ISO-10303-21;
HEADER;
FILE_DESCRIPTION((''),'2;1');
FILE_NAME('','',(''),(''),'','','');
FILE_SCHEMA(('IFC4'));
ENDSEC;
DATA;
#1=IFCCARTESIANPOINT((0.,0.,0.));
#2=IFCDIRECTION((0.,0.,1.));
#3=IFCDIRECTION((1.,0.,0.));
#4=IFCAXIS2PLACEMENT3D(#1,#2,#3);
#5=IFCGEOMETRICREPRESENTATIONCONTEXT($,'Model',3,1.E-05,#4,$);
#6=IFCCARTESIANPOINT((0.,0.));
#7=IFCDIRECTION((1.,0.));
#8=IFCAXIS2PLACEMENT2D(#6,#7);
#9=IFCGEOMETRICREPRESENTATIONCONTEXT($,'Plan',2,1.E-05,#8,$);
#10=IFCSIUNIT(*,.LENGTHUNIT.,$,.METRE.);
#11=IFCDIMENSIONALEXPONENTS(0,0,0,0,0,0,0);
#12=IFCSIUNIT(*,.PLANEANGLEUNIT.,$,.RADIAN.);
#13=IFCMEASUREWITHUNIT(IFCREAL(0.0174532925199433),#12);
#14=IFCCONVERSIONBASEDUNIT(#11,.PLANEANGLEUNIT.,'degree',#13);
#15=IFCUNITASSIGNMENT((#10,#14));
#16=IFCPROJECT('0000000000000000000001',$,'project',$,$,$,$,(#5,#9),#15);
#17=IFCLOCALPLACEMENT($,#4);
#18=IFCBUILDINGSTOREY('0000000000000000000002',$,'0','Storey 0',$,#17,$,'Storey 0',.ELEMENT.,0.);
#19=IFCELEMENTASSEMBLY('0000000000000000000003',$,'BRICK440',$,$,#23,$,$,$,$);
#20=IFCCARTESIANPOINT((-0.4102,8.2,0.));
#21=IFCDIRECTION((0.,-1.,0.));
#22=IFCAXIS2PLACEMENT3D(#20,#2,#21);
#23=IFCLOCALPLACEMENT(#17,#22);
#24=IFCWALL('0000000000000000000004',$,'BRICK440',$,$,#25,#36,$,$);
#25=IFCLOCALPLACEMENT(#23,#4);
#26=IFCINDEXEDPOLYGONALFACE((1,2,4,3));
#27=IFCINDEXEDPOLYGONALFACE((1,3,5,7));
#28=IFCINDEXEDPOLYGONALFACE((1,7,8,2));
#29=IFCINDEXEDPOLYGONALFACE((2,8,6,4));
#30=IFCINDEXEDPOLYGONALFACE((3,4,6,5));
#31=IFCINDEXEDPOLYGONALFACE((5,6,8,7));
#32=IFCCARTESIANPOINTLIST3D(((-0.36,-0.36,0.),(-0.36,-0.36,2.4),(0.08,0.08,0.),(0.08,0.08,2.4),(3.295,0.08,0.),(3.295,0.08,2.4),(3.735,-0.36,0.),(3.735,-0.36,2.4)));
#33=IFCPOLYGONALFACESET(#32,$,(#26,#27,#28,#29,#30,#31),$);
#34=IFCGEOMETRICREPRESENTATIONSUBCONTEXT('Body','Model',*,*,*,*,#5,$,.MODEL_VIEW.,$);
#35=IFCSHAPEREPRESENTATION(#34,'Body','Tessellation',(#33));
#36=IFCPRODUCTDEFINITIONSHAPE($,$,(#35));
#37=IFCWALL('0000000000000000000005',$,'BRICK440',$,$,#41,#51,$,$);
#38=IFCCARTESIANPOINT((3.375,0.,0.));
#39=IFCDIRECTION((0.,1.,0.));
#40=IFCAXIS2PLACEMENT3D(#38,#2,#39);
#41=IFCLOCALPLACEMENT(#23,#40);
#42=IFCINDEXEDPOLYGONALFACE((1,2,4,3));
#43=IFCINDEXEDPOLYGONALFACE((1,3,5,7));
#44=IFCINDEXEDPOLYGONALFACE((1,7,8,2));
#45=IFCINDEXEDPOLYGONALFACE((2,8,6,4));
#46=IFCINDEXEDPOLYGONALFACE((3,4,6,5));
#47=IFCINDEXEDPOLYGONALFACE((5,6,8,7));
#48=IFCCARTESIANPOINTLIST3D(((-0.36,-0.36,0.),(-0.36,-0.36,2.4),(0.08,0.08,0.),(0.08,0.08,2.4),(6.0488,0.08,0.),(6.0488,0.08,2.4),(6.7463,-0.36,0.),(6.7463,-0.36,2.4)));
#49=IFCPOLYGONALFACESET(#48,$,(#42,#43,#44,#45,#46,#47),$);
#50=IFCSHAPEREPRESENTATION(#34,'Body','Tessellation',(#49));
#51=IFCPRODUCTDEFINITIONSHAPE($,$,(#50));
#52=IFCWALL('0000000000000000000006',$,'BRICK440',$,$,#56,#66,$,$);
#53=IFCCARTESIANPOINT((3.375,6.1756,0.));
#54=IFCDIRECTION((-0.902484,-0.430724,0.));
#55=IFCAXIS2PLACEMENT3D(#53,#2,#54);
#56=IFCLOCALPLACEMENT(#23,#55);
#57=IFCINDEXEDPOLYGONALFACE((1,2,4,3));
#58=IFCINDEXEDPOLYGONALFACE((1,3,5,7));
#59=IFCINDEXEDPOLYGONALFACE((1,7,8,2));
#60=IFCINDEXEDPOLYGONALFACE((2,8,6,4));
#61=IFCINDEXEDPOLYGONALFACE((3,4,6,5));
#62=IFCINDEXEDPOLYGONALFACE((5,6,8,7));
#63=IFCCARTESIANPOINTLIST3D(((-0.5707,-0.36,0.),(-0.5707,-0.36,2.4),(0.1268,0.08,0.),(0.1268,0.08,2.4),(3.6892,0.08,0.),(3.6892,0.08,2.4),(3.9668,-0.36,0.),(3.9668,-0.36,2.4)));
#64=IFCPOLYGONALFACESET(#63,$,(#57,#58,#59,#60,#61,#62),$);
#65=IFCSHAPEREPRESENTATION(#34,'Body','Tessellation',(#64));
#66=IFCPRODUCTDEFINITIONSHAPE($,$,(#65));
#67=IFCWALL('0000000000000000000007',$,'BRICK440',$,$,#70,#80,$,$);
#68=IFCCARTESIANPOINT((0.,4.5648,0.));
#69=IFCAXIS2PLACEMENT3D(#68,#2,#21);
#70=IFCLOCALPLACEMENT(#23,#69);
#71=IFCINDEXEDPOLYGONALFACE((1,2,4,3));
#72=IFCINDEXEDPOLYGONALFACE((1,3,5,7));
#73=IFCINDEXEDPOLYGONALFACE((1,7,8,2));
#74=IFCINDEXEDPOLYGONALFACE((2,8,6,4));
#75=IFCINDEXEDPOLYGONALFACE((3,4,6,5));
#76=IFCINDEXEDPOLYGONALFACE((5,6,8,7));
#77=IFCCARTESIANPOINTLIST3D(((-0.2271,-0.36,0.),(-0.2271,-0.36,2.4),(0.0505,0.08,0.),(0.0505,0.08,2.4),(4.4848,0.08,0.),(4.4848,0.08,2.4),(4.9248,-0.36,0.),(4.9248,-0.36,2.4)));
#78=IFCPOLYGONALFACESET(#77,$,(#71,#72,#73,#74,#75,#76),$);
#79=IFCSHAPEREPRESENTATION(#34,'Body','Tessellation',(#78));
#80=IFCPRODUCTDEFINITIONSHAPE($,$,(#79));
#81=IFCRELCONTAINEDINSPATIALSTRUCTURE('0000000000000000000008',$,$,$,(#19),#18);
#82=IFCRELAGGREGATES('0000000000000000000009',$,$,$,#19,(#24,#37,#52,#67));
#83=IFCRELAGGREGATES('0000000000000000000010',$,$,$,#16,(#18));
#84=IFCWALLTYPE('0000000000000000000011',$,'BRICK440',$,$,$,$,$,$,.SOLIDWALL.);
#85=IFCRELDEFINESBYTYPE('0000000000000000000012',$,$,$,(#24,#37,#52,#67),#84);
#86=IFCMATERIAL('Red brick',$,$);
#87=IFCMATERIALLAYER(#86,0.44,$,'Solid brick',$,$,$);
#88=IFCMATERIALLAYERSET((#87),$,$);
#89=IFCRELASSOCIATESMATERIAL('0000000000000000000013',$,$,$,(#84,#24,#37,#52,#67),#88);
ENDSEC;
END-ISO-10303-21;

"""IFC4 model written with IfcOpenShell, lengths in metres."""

from ifc_helpers import new_model, entity, si_unit, converted_unit, frame, origin, origin_with_axes, origin_2d_with_axis, place, context, subcontext, project, spatial, polyline, outline, extrude, material, layer, layer_set, layer_usage, type_object, element, aggregate, save


model = new_model("IFC4")

# Units and contexts
model_context = context("Model", 3, precision=1e-05, world=origin_with_axes())
plan_context = context("Plan", 2, precision=1e-05, world=origin_2d_with_axis())
body_context = subcontext(model_context, "Body", "Model", "MODEL_VIEW")
ifc_project = project(units=[si_unit("LENGTHUNIT", "METRE"), converted_unit("PLANEANGLEUNIT", "degree", entity("IfcReal", 0.0174532925199433), si_unit("PLANEANGLEUNIT", "RADIAN"), dimensions=[0, 0, 0, 0, 0, 0, 0])], contexts=[model_context, plan_context])

# Storey
storey_placement = place(None, origin_with_axes())
storey = spatial("IfcBuildingStorey", under=ifc_project, at=storey_placement, Name="0", Description="Storey 0", LongName="Storey 0", CompositionType="ELEMENT", Elevation=0.0)

# Element assembly, walls
assembly_1_placement = place(storey_placement, frame((-0.4102, 8.2, 0.0), z_axis=(0.0, 0.0, 1.0), x_axis=(0.0, -1.0, 0.0)))
assembly_1 = element("IfcElementAssembly", 1, at=assembly_1_placement, inside=storey, Name="BRICK440")
ifc_material_1 = material(Name="Red brick")
ifc_layer_1 = layer(ifc_material_1, 0.44, Name="Solid brick")
ifc_layer_set_1 = layer_set([ifc_layer_1])
ifc_layer_usage_1 = layer_usage(ifc_layer_set_1, "AXIS2", "POSITIVE", -0.36)
wall_type = type_object("IfcWallType", Name="BRICK440", PredefinedType="SOLIDWALL", material=ifc_layer_set_1)
wall_1_placement = place(assembly_1_placement, origin_with_axes())
wall_1 = element("IfcWall", 2, at=wall_1_placement, type_object=wall_type, material=ifc_layer_usage_1, Name="BRICK440", context=body_context, shape_type="SweptSolid", body=[
    extrude(outline(polyline([(0.08, 0.08), (-0.36, -0.36), (3.735, -0.36), (3.295, 0.08), (0.08, 0.08)])), origin(), (0.0, 0.0, 1.0), 2.4),
])
ifc_layer_usage_2 = layer_usage(ifc_layer_set_1, "AXIS2", "POSITIVE", -0.36)
wall_2_placement = place(assembly_1_placement, frame((3.375, 0.0, 0.0), z_axis=(0.0, 0.0, 1.0), x_axis=(0.0, 1.0, 0.0)))
wall_2 = element("IfcWall", 3, at=wall_2_placement, type_object=wall_type, material=ifc_layer_usage_2, Name="BRICK440", context=body_context, shape_type="SweptSolid", body=[
    extrude(outline(polyline([(0.08, 0.08), (-0.36, -0.36), (6.7463, -0.36), (6.0488, 0.08), (0.08, 0.08)])), origin(), (0.0, 0.0, 1.0), 2.4),
])
ifc_layer_usage_3 = layer_usage(ifc_layer_set_1, "AXIS2", "POSITIVE", -0.36)
wall_3_placement = place(assembly_1_placement, frame((3.375, 6.1756, 0.0), z_axis=(0.0, 0.0, 1.0), x_axis=(-0.902484, -0.430724, 0.0)))
wall_3 = element("IfcWall", 4, at=wall_3_placement, type_object=wall_type, material=ifc_layer_usage_3, Name="BRICK440", context=body_context, shape_type="SweptSolid", body=[
    extrude(outline(polyline([(0.1268, 0.08), (-0.5707, -0.36), (3.9668, -0.36), (3.6892, 0.08), (0.1268, 0.08)])), origin(), (0.0, 0.0, 1.0), 2.4),
])
ifc_layer_usage_4 = layer_usage(ifc_layer_set_1, "AXIS2", "POSITIVE", -0.36)
wall_4_placement = place(assembly_1_placement, frame((0.0, 4.5648, 0.0), z_axis=(0.0, 0.0, 1.0), x_axis=(0.0, -1.0, 0.0)))
wall_4 = element("IfcWall", 5, at=wall_4_placement, type_object=wall_type, material=ifc_layer_usage_4, Name="BRICK440", context=body_context, shape_type="SweptSolid", body=[
    extrude(outline(polyline([(0.0505, 0.08), (-0.2271, -0.36), (4.9248, -0.36), (4.4848, 0.08), (0.0505, 0.08)])), origin(), (0.0, 0.0, 1.0), 2.4),
])
aggregate(assembly_1, [wall_1, wall_2, wall_3, wall_4])

save(model, "model.ifc")
